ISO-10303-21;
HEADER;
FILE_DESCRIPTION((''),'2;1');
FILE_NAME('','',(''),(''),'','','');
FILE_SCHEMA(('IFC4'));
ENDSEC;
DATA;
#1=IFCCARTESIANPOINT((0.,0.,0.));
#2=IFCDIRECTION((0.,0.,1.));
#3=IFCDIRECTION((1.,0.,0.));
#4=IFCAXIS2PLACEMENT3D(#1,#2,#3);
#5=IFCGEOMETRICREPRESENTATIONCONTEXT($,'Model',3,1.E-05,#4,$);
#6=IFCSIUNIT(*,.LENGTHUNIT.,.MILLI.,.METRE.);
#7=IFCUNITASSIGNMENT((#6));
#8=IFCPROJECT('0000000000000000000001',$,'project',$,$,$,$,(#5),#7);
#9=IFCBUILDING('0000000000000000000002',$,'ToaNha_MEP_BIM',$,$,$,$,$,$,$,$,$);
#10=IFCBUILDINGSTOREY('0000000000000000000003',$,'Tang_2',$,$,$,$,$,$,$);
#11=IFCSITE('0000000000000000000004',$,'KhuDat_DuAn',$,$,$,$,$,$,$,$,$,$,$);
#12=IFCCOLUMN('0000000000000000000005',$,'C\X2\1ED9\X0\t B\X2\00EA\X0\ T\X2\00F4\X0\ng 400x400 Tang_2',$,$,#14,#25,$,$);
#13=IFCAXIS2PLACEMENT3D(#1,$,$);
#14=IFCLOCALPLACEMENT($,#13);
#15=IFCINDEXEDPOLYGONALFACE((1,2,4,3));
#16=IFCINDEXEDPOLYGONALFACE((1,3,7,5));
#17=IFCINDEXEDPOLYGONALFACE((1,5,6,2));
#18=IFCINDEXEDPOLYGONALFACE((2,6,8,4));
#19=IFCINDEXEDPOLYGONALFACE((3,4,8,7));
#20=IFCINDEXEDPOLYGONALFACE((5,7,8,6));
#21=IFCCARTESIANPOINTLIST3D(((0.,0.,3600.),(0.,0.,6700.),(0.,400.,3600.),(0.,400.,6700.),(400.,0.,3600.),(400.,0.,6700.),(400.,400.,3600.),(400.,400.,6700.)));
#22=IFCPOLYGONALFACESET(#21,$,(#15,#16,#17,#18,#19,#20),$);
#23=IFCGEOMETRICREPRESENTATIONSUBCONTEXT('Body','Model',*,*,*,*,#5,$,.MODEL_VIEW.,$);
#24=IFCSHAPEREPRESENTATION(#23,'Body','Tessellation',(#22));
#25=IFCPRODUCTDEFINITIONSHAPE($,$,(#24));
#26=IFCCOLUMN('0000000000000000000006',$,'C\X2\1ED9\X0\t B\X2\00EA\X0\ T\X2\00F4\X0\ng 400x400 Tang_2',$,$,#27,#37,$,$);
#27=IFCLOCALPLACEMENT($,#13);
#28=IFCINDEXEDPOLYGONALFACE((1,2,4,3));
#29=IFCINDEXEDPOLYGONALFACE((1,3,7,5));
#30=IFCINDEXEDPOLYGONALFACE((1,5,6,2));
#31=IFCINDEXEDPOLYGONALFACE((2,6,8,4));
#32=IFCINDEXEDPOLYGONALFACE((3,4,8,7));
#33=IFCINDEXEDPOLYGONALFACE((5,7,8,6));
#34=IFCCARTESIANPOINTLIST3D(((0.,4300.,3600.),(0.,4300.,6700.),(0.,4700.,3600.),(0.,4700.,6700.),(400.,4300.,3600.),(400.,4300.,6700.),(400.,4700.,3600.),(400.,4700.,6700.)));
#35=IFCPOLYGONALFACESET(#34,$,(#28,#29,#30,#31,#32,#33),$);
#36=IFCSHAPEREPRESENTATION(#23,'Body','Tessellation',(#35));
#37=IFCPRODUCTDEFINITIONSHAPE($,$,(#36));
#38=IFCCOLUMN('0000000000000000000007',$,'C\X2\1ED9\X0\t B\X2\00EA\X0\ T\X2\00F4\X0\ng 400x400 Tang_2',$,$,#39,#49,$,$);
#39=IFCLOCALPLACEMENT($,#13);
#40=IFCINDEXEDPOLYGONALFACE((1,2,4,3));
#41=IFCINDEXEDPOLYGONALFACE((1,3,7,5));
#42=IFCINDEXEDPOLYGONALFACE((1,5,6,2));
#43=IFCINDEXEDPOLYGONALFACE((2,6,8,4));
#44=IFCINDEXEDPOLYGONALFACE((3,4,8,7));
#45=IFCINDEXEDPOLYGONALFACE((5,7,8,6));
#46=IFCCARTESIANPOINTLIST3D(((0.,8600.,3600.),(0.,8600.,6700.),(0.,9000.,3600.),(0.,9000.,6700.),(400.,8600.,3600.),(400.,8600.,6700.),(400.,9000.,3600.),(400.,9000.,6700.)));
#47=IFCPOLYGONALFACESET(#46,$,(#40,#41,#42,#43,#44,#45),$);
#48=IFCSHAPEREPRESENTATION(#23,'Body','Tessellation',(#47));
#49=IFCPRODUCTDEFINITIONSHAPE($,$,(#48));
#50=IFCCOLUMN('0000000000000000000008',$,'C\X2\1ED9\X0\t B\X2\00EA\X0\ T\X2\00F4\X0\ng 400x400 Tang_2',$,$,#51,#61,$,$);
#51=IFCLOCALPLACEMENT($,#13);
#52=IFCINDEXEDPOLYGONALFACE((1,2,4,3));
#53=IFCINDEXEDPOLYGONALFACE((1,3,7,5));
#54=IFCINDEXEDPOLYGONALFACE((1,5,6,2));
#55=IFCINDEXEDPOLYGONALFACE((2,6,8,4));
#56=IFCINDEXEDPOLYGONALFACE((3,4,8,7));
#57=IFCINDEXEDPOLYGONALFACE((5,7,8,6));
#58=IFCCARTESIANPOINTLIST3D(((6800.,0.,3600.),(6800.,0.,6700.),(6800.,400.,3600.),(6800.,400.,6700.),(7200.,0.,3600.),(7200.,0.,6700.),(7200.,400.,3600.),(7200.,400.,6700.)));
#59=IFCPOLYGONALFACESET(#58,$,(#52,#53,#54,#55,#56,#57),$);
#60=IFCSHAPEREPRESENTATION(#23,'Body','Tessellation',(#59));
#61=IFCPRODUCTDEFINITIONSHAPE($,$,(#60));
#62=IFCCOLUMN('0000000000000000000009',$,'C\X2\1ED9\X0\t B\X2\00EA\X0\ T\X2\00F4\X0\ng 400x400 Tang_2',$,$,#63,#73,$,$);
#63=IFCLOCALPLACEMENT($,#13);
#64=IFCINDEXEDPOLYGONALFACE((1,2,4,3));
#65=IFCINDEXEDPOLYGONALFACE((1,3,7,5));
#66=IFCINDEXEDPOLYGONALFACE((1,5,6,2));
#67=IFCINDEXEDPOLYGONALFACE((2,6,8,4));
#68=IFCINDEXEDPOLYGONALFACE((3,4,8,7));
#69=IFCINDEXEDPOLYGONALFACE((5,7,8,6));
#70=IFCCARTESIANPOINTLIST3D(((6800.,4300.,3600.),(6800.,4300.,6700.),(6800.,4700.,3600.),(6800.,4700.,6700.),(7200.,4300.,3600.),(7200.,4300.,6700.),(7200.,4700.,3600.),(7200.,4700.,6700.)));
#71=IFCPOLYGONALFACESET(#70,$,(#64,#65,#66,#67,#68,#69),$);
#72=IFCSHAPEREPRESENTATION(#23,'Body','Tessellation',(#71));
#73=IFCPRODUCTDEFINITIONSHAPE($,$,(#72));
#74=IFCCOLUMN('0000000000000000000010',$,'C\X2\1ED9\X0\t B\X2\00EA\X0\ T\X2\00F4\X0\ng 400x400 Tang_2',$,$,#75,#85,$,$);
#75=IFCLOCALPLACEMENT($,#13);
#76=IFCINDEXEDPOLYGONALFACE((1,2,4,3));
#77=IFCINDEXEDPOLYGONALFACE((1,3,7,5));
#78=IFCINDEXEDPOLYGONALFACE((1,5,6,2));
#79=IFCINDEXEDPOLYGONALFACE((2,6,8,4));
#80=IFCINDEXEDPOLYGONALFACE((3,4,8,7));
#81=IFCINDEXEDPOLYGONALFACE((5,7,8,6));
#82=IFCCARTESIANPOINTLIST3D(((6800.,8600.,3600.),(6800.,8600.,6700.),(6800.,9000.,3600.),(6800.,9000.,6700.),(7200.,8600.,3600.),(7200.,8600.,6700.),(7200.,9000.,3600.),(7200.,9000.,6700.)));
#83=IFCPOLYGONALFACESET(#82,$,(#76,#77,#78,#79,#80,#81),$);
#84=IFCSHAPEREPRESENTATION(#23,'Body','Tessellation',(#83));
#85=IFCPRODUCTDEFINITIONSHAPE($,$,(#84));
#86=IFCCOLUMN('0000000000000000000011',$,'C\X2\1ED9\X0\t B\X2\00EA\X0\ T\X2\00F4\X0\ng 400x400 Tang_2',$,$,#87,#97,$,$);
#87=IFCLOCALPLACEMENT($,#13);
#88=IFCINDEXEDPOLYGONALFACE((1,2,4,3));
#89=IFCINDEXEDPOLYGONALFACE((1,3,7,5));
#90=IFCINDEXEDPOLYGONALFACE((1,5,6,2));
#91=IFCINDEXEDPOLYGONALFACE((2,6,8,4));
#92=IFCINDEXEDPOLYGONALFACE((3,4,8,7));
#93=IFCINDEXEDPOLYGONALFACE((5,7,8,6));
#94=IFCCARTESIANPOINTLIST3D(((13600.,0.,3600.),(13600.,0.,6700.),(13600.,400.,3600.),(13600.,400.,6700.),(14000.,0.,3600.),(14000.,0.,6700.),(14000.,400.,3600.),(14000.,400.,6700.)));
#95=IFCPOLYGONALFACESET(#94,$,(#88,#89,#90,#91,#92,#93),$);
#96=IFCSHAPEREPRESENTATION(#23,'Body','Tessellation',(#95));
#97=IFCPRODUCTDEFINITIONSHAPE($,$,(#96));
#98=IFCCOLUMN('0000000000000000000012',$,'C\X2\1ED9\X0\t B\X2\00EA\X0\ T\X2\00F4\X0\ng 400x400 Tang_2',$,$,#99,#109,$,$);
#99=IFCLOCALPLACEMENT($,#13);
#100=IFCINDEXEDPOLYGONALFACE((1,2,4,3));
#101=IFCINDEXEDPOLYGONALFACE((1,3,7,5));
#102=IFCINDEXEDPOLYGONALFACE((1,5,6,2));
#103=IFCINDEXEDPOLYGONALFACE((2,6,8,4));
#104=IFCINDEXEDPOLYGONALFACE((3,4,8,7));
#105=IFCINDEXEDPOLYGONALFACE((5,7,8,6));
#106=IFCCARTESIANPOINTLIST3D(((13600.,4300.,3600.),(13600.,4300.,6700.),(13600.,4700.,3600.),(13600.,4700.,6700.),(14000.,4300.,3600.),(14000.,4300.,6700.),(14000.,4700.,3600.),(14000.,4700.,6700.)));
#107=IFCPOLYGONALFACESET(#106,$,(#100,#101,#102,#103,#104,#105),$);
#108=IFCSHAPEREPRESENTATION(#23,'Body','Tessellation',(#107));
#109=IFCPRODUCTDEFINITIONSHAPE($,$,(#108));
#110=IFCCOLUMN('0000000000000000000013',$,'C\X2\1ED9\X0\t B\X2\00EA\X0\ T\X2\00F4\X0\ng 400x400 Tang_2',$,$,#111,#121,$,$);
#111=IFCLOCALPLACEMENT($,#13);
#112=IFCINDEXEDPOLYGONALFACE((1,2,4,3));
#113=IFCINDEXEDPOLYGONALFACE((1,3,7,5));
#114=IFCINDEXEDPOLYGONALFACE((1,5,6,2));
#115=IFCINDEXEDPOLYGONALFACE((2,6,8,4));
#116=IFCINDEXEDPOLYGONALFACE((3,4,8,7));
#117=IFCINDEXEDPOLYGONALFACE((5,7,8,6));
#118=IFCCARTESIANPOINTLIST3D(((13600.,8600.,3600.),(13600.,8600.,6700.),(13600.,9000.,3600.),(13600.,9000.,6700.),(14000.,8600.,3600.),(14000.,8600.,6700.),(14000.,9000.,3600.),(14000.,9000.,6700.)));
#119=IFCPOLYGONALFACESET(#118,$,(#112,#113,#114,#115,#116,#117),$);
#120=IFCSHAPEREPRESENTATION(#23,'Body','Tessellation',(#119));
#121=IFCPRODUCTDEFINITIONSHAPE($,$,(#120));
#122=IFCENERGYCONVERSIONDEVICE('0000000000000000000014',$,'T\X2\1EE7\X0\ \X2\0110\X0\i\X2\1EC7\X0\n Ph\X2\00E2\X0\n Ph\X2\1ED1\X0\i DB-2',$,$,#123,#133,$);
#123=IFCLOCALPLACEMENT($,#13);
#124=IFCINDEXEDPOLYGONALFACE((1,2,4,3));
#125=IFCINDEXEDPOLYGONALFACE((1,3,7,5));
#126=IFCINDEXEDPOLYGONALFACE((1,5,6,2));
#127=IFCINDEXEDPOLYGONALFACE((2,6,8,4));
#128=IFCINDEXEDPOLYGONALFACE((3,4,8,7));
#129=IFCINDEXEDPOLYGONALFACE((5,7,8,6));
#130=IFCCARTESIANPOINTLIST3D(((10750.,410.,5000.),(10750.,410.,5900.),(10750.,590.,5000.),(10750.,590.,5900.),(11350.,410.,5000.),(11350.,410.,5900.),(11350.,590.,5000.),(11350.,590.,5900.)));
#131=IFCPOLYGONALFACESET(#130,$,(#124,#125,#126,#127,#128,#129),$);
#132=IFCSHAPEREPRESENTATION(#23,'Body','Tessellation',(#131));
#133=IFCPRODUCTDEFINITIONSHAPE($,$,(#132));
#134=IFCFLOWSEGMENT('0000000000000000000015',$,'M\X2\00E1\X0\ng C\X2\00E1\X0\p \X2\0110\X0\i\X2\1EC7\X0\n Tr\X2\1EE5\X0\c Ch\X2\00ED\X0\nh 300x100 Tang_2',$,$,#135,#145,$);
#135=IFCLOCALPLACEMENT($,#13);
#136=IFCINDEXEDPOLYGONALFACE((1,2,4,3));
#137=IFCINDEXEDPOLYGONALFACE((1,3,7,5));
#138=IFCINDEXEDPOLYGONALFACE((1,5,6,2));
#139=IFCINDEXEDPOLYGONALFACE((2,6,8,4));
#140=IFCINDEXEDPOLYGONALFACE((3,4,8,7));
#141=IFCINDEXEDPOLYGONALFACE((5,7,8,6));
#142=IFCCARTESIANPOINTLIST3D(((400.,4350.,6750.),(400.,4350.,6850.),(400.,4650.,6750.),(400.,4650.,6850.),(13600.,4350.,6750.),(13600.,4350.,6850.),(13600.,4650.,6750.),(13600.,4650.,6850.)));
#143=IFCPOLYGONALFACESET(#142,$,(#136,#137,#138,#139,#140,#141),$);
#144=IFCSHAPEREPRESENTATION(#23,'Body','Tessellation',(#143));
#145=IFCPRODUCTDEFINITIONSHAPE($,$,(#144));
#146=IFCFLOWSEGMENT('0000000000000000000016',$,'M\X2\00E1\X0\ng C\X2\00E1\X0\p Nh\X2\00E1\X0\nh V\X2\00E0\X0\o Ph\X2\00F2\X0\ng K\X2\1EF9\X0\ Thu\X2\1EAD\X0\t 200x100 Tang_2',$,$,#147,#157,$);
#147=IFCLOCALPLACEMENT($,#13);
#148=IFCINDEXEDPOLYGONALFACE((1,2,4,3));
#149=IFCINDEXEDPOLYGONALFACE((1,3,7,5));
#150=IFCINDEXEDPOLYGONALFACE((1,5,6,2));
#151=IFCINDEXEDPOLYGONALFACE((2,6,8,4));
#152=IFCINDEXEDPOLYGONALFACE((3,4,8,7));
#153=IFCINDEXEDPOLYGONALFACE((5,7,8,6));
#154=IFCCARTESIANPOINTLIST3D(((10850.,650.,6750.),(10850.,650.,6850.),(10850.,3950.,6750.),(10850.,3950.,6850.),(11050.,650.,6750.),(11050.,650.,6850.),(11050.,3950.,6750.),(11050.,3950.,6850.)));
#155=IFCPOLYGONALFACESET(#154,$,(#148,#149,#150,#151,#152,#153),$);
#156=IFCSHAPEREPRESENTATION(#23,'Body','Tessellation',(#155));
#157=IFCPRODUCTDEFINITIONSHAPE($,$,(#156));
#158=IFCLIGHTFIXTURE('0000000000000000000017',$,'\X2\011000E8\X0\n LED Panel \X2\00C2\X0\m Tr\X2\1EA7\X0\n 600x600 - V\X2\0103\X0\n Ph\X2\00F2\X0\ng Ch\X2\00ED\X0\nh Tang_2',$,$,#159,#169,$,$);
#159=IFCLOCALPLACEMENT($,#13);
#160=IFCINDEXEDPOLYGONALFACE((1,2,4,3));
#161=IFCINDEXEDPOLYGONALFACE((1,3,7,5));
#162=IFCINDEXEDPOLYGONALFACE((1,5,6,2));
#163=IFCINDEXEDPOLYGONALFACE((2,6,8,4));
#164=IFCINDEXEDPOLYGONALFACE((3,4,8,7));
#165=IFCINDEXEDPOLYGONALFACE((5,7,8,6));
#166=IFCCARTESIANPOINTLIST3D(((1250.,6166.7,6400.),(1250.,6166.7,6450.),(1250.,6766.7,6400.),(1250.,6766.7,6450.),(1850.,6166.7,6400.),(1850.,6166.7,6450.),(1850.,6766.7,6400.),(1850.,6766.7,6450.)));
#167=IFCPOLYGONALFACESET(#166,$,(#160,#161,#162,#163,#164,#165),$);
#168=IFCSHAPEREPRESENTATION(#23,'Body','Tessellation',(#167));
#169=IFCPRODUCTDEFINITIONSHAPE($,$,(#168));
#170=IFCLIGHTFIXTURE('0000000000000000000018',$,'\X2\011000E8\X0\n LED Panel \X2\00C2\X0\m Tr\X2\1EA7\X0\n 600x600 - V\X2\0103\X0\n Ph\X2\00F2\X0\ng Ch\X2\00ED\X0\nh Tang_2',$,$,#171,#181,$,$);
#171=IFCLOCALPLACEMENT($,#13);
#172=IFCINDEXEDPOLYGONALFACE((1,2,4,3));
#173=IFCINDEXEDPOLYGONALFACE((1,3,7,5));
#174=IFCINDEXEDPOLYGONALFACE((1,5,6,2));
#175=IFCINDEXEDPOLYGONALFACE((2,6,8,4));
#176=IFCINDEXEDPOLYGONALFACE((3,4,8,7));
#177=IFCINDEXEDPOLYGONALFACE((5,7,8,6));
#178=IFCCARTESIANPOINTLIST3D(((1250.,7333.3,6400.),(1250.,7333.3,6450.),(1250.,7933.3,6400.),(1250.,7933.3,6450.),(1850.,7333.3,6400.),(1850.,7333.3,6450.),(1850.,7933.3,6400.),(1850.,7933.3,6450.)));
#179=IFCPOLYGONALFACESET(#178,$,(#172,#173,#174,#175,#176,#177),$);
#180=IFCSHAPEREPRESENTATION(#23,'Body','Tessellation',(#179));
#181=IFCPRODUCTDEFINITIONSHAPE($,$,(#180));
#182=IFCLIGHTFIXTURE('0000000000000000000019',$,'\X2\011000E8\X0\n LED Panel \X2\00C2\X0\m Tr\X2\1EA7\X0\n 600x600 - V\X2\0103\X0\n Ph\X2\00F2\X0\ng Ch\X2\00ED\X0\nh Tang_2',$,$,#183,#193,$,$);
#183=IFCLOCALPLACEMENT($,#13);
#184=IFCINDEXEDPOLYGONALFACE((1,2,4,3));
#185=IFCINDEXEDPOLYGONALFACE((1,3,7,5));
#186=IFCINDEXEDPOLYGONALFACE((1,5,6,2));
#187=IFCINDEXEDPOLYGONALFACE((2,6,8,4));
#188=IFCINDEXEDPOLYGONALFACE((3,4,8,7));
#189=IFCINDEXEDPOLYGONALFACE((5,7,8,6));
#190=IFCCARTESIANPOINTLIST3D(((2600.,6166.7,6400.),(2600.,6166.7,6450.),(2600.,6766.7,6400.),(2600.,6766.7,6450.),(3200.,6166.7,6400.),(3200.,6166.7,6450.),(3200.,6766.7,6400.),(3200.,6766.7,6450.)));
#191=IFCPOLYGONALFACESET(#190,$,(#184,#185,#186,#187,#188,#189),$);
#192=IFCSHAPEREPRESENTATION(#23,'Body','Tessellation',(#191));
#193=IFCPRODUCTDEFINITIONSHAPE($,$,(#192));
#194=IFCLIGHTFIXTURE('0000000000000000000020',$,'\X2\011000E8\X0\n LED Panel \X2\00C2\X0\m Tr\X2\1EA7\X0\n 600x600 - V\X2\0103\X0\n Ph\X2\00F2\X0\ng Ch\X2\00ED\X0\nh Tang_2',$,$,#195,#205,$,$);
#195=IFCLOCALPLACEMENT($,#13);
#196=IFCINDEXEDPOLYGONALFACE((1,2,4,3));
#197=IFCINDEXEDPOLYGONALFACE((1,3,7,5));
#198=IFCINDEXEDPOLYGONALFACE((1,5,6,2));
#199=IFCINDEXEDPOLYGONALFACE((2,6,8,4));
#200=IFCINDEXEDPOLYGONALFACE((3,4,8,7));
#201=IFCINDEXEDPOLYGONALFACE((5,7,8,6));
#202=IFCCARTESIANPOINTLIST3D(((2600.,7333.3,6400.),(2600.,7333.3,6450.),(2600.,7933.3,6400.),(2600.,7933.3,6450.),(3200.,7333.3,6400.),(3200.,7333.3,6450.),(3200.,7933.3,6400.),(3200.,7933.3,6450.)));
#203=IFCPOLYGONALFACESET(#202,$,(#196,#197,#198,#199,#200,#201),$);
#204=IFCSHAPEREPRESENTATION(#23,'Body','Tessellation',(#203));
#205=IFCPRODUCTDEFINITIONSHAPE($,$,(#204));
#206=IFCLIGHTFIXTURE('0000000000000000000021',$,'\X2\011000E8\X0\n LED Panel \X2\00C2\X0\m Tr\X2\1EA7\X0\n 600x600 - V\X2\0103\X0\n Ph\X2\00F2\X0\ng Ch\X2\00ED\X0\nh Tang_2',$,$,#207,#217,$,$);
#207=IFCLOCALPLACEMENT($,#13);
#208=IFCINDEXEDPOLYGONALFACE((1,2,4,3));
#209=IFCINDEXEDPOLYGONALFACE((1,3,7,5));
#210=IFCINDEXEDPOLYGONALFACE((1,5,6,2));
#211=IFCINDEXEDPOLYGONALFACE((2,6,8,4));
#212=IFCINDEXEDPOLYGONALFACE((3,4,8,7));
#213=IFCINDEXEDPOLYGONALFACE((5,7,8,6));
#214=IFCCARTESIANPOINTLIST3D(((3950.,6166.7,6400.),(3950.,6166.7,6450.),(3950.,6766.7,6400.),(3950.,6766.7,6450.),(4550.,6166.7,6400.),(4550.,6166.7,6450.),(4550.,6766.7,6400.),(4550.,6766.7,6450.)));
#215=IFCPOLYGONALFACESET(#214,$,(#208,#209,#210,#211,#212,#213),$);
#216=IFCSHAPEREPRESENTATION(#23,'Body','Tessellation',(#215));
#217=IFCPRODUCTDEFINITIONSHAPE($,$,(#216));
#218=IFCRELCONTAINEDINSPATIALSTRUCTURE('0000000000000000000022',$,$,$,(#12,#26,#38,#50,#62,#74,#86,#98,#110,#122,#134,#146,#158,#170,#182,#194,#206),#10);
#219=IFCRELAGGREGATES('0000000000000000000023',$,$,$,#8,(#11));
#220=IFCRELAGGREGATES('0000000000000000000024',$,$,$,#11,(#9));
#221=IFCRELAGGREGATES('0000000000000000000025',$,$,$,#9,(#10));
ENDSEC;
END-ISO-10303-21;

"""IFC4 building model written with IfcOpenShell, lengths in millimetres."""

from ifc_helpers import new_model, si_unit, frame, origin_with_axes, context, subcontext, project, spatial, polyline, outline, extrude, element, save


model = new_model("IFC4")

# Units and contexts
model_context = context("Model", 3, precision=1e-05, world=origin_with_axes())
body_context = subcontext(model_context, "Body", "Model", "MODEL_VIEW")
ifc_project = project(units=[si_unit("LENGTHUNIT", "METRE", prefix="MILLI")], contexts=[model_context])

# Site, building, storey
site = spatial("IfcSite", under=ifc_project, Name="KhuDat_DuAn")
building = spatial("IfcBuilding", under=site, Name="ToaNha_MEP_BIM")
storey = spatial("IfcBuildingStorey", under=building, Name="Tang_2")

# Columns
element("IfcColumn", 1, inside=storey, Name="Cột Bê Tông 400x400 Tang_2", context=body_context, shape_type="SweptSolid", body=[
    extrude(outline(polyline([(0.0, 0.0), (400.0, 0.0), (400.0, 400.0), (0.0, 400.0), (0.0, 0.0)])), frame((0.0, 0.0, 3600.0), z_axis=(0.0, 0.0, 1.0), x_axis=(1.0, 0.0, 0.0)), (0.0, 0.0, 1.0), 3100.0),
])
element("IfcColumn", 2, inside=storey, Name="Cột Bê Tông 400x400 Tang_2", context=body_context, shape_type="SweptSolid", body=[
    extrude(outline(polyline([(0.0, 4300.0), (400.0, 4300.0), (400.0, 4700.0), (0.0, 4700.0), (0.0, 4300.0)])), frame((0.0, 0.0, 3600.0), z_axis=(0.0, 0.0, 1.0), x_axis=(1.0, 0.0, 0.0)), (0.0, 0.0, 1.0), 3100.0),
])
element("IfcColumn", 3, inside=storey, Name="Cột Bê Tông 400x400 Tang_2", context=body_context, shape_type="SweptSolid", body=[
    extrude(outline(polyline([(0.0, 8600.0), (400.0, 8600.0), (400.0, 9000.0), (0.0, 9000.0), (0.0, 8600.0)])), frame((0.0, 0.0, 3600.0), z_axis=(0.0, 0.0, 1.0), x_axis=(1.0, 0.0, 0.0)), (0.0, 0.0, 1.0), 3100.0),
])
element("IfcColumn", 4, inside=storey, Name="Cột Bê Tông 400x400 Tang_2", context=body_context, shape_type="SweptSolid", body=[
    extrude(outline(polyline([(6800.0, 0.0), (7200.0, 0.0), (7200.0, 400.0), (6800.0, 400.0), (6800.0, 0.0)])), frame((0.0, 0.0, 3600.0), z_axis=(0.0, 0.0, 1.0), x_axis=(1.0, 0.0, 0.0)), (0.0, 0.0, 1.0), 3100.0),
])
element("IfcColumn", 5, inside=storey, Name="Cột Bê Tông 400x400 Tang_2", context=body_context, shape_type="SweptSolid", body=[
    extrude(outline(polyline([(6800.0, 4300.0), (7200.0, 4300.0), (7200.0, 4700.0), (6800.0, 4700.0), (6800.0, 4300.0)])), frame((0.0, 0.0, 3600.0), z_axis=(0.0, 0.0, 1.0), x_axis=(1.0, 0.0, 0.0)), (0.0, 0.0, 1.0), 3100.0),
])
element("IfcColumn", 6, inside=storey, Name="Cột Bê Tông 400x400 Tang_2", context=body_context, shape_type="SweptSolid", body=[
    extrude(outline(polyline([(6800.0, 8600.0), (7200.0, 8600.0), (7200.0, 9000.0), (6800.0, 9000.0), (6800.0, 8600.0)])), frame((0.0, 0.0, 3600.0), z_axis=(0.0, 0.0, 1.0), x_axis=(1.0, 0.0, 0.0)), (0.0, 0.0, 1.0), 3100.0),
])
element("IfcColumn", 7, inside=storey, Name="Cột Bê Tông 400x400 Tang_2", context=body_context, shape_type="SweptSolid", body=[
    extrude(outline(polyline([(13600.0, 0.0), (14000.0, 0.0), (14000.0, 400.0), (13600.0, 400.0), (13600.0, 0.0)])), frame((0.0, 0.0, 3600.0), z_axis=(0.0, 0.0, 1.0), x_axis=(1.0, 0.0, 0.0)), (0.0, 0.0, 1.0), 3100.0),
])
element("IfcColumn", 8, inside=storey, Name="Cột Bê Tông 400x400 Tang_2", context=body_context, shape_type="SweptSolid", body=[
    extrude(outline(polyline([(13600.0, 4300.0), (14000.0, 4300.0), (14000.0, 4700.0), (13600.0, 4700.0), (13600.0, 4300.0)])), frame((0.0, 0.0, 3600.0), z_axis=(0.0, 0.0, 1.0), x_axis=(1.0, 0.0, 0.0)), (0.0, 0.0, 1.0), 3100.0),
])
element("IfcColumn", 9, inside=storey, Name="Cột Bê Tông 400x400 Tang_2", context=body_context, shape_type="SweptSolid", body=[
    extrude(outline(polyline([(13600.0, 8600.0), (14000.0, 8600.0), (14000.0, 9000.0), (13600.0, 9000.0), (13600.0, 8600.0)])), frame((0.0, 0.0, 3600.0), z_axis=(0.0, 0.0, 1.0), x_axis=(1.0, 0.0, 0.0)), (0.0, 0.0, 1.0), 3100.0),
])

# Energy conversion device
element("IfcEnergyConversionDevice", 10, inside=storey, Name="Tủ Điện Phân Phối DB-2", context=body_context, shape_type="SweptSolid", body=[
    extrude(outline(polyline([(10750.0, 410.0), (11350.0, 410.0), (11350.0, 590.0), (10750.0, 590.0), (10750.0, 410.0)])), frame((0.0, 0.0, 5000.0), z_axis=(0.0, 0.0, 1.0), x_axis=(1.0, 0.0, 0.0)), (0.0, 0.0, 1.0), 900.0),
])

# Flow segments
element("IfcFlowSegment", 11, inside=storey, Name="Máng Cáp Điện Trục Chính 300x100 Tang_2", context=body_context, shape_type="SweptSolid", body=[
    extrude(outline(polyline([(400.0, 4350.0), (13600.0, 4350.0), (13600.0, 4650.0), (400.0, 4650.0), (400.0, 4350.0)])), frame((0.0, 0.0, 6750.0), z_axis=(0.0, 0.0, 1.0), x_axis=(1.0, 0.0, 0.0)), (0.0, 0.0, 1.0), 100.0),
])
element("IfcFlowSegment", 12, inside=storey, Name="Máng Cáp Nhánh Vào Phòng Kỹ Thuật 200x100 Tang_2", context=body_context, shape_type="SweptSolid", body=[
    extrude(outline(polyline([(10850.0, 650.0), (11050.0, 650.0), (11050.0, 3950.0), (10850.0, 3950.0), (10850.0, 650.0)])), frame((0.0, 0.0, 6750.0), z_axis=(0.0, 0.0, 1.0), x_axis=(1.0, 0.0, 0.0)), (0.0, 0.0, 1.0), 100.0),
])

# Light fixtures
element("IfcLightFixture", 13, inside=storey, Name="Đèn LED Panel Âm Trần 600x600 - Văn Phòng Chính Tang_2", context=body_context, shape_type="SweptSolid", body=[
    extrude(outline(polyline([(1250.0, 6166.7), (1850.0, 6166.7), (1850.0, 6766.7), (1250.0, 6766.7), (1250.0, 6166.7)])), frame((0.0, 0.0, 6400.0), z_axis=(0.0, 0.0, 1.0), x_axis=(1.0, 0.0, 0.0)), (0.0, 0.0, 1.0), 50.0),
])
element("IfcLightFixture", 14, inside=storey, Name="Đèn LED Panel Âm Trần 600x600 - Văn Phòng Chính Tang_2", context=body_context, shape_type="SweptSolid", body=[
    extrude(outline(polyline([(1250.0, 7333.3), (1850.0, 7333.3), (1850.0, 7933.3), (1250.0, 7933.3), (1250.0, 7333.3)])), frame((0.0, 0.0, 6400.0), z_axis=(0.0, 0.0, 1.0), x_axis=(1.0, 0.0, 0.0)), (0.0, 0.0, 1.0), 50.0),
])
element("IfcLightFixture", 15, inside=storey, Name="Đèn LED Panel Âm Trần 600x600 - Văn Phòng Chính Tang_2", context=body_context, shape_type="SweptSolid", body=[
    extrude(outline(polyline([(2600.0, 6166.7), (3200.0, 6166.7), (3200.0, 6766.7), (2600.0, 6766.7), (2600.0, 6166.7)])), frame((0.0, 0.0, 6400.0), z_axis=(0.0, 0.0, 1.0), x_axis=(1.0, 0.0, 0.0)), (0.0, 0.0, 1.0), 50.0),
])
element("IfcLightFixture", 16, inside=storey, Name="Đèn LED Panel Âm Trần 600x600 - Văn Phòng Chính Tang_2", context=body_context, shape_type="SweptSolid", body=[
    extrude(outline(polyline([(2600.0, 7333.3), (3200.0, 7333.3), (3200.0, 7933.3), (2600.0, 7933.3), (2600.0, 7333.3)])), frame((0.0, 0.0, 6400.0), z_axis=(0.0, 0.0, 1.0), x_axis=(1.0, 0.0, 0.0)), (0.0, 0.0, 1.0), 50.0),
])
element("IfcLightFixture", 17, inside=storey, Name="Đèn LED Panel Âm Trần 600x600 - Văn Phòng Chính Tang_2", context=body_context, shape_type="SweptSolid", body=[
    extrude(outline(polyline([(3950.0, 6166.7), (4550.0, 6166.7), (4550.0, 6766.7), (3950.0, 6766.7), (3950.0, 6166.7)])), frame((0.0, 0.0, 6400.0), z_axis=(0.0, 0.0, 1.0), x_axis=(1.0, 0.0, 0.0)), (0.0, 0.0, 1.0), 50.0),
])

save(model, "model.ifc")
